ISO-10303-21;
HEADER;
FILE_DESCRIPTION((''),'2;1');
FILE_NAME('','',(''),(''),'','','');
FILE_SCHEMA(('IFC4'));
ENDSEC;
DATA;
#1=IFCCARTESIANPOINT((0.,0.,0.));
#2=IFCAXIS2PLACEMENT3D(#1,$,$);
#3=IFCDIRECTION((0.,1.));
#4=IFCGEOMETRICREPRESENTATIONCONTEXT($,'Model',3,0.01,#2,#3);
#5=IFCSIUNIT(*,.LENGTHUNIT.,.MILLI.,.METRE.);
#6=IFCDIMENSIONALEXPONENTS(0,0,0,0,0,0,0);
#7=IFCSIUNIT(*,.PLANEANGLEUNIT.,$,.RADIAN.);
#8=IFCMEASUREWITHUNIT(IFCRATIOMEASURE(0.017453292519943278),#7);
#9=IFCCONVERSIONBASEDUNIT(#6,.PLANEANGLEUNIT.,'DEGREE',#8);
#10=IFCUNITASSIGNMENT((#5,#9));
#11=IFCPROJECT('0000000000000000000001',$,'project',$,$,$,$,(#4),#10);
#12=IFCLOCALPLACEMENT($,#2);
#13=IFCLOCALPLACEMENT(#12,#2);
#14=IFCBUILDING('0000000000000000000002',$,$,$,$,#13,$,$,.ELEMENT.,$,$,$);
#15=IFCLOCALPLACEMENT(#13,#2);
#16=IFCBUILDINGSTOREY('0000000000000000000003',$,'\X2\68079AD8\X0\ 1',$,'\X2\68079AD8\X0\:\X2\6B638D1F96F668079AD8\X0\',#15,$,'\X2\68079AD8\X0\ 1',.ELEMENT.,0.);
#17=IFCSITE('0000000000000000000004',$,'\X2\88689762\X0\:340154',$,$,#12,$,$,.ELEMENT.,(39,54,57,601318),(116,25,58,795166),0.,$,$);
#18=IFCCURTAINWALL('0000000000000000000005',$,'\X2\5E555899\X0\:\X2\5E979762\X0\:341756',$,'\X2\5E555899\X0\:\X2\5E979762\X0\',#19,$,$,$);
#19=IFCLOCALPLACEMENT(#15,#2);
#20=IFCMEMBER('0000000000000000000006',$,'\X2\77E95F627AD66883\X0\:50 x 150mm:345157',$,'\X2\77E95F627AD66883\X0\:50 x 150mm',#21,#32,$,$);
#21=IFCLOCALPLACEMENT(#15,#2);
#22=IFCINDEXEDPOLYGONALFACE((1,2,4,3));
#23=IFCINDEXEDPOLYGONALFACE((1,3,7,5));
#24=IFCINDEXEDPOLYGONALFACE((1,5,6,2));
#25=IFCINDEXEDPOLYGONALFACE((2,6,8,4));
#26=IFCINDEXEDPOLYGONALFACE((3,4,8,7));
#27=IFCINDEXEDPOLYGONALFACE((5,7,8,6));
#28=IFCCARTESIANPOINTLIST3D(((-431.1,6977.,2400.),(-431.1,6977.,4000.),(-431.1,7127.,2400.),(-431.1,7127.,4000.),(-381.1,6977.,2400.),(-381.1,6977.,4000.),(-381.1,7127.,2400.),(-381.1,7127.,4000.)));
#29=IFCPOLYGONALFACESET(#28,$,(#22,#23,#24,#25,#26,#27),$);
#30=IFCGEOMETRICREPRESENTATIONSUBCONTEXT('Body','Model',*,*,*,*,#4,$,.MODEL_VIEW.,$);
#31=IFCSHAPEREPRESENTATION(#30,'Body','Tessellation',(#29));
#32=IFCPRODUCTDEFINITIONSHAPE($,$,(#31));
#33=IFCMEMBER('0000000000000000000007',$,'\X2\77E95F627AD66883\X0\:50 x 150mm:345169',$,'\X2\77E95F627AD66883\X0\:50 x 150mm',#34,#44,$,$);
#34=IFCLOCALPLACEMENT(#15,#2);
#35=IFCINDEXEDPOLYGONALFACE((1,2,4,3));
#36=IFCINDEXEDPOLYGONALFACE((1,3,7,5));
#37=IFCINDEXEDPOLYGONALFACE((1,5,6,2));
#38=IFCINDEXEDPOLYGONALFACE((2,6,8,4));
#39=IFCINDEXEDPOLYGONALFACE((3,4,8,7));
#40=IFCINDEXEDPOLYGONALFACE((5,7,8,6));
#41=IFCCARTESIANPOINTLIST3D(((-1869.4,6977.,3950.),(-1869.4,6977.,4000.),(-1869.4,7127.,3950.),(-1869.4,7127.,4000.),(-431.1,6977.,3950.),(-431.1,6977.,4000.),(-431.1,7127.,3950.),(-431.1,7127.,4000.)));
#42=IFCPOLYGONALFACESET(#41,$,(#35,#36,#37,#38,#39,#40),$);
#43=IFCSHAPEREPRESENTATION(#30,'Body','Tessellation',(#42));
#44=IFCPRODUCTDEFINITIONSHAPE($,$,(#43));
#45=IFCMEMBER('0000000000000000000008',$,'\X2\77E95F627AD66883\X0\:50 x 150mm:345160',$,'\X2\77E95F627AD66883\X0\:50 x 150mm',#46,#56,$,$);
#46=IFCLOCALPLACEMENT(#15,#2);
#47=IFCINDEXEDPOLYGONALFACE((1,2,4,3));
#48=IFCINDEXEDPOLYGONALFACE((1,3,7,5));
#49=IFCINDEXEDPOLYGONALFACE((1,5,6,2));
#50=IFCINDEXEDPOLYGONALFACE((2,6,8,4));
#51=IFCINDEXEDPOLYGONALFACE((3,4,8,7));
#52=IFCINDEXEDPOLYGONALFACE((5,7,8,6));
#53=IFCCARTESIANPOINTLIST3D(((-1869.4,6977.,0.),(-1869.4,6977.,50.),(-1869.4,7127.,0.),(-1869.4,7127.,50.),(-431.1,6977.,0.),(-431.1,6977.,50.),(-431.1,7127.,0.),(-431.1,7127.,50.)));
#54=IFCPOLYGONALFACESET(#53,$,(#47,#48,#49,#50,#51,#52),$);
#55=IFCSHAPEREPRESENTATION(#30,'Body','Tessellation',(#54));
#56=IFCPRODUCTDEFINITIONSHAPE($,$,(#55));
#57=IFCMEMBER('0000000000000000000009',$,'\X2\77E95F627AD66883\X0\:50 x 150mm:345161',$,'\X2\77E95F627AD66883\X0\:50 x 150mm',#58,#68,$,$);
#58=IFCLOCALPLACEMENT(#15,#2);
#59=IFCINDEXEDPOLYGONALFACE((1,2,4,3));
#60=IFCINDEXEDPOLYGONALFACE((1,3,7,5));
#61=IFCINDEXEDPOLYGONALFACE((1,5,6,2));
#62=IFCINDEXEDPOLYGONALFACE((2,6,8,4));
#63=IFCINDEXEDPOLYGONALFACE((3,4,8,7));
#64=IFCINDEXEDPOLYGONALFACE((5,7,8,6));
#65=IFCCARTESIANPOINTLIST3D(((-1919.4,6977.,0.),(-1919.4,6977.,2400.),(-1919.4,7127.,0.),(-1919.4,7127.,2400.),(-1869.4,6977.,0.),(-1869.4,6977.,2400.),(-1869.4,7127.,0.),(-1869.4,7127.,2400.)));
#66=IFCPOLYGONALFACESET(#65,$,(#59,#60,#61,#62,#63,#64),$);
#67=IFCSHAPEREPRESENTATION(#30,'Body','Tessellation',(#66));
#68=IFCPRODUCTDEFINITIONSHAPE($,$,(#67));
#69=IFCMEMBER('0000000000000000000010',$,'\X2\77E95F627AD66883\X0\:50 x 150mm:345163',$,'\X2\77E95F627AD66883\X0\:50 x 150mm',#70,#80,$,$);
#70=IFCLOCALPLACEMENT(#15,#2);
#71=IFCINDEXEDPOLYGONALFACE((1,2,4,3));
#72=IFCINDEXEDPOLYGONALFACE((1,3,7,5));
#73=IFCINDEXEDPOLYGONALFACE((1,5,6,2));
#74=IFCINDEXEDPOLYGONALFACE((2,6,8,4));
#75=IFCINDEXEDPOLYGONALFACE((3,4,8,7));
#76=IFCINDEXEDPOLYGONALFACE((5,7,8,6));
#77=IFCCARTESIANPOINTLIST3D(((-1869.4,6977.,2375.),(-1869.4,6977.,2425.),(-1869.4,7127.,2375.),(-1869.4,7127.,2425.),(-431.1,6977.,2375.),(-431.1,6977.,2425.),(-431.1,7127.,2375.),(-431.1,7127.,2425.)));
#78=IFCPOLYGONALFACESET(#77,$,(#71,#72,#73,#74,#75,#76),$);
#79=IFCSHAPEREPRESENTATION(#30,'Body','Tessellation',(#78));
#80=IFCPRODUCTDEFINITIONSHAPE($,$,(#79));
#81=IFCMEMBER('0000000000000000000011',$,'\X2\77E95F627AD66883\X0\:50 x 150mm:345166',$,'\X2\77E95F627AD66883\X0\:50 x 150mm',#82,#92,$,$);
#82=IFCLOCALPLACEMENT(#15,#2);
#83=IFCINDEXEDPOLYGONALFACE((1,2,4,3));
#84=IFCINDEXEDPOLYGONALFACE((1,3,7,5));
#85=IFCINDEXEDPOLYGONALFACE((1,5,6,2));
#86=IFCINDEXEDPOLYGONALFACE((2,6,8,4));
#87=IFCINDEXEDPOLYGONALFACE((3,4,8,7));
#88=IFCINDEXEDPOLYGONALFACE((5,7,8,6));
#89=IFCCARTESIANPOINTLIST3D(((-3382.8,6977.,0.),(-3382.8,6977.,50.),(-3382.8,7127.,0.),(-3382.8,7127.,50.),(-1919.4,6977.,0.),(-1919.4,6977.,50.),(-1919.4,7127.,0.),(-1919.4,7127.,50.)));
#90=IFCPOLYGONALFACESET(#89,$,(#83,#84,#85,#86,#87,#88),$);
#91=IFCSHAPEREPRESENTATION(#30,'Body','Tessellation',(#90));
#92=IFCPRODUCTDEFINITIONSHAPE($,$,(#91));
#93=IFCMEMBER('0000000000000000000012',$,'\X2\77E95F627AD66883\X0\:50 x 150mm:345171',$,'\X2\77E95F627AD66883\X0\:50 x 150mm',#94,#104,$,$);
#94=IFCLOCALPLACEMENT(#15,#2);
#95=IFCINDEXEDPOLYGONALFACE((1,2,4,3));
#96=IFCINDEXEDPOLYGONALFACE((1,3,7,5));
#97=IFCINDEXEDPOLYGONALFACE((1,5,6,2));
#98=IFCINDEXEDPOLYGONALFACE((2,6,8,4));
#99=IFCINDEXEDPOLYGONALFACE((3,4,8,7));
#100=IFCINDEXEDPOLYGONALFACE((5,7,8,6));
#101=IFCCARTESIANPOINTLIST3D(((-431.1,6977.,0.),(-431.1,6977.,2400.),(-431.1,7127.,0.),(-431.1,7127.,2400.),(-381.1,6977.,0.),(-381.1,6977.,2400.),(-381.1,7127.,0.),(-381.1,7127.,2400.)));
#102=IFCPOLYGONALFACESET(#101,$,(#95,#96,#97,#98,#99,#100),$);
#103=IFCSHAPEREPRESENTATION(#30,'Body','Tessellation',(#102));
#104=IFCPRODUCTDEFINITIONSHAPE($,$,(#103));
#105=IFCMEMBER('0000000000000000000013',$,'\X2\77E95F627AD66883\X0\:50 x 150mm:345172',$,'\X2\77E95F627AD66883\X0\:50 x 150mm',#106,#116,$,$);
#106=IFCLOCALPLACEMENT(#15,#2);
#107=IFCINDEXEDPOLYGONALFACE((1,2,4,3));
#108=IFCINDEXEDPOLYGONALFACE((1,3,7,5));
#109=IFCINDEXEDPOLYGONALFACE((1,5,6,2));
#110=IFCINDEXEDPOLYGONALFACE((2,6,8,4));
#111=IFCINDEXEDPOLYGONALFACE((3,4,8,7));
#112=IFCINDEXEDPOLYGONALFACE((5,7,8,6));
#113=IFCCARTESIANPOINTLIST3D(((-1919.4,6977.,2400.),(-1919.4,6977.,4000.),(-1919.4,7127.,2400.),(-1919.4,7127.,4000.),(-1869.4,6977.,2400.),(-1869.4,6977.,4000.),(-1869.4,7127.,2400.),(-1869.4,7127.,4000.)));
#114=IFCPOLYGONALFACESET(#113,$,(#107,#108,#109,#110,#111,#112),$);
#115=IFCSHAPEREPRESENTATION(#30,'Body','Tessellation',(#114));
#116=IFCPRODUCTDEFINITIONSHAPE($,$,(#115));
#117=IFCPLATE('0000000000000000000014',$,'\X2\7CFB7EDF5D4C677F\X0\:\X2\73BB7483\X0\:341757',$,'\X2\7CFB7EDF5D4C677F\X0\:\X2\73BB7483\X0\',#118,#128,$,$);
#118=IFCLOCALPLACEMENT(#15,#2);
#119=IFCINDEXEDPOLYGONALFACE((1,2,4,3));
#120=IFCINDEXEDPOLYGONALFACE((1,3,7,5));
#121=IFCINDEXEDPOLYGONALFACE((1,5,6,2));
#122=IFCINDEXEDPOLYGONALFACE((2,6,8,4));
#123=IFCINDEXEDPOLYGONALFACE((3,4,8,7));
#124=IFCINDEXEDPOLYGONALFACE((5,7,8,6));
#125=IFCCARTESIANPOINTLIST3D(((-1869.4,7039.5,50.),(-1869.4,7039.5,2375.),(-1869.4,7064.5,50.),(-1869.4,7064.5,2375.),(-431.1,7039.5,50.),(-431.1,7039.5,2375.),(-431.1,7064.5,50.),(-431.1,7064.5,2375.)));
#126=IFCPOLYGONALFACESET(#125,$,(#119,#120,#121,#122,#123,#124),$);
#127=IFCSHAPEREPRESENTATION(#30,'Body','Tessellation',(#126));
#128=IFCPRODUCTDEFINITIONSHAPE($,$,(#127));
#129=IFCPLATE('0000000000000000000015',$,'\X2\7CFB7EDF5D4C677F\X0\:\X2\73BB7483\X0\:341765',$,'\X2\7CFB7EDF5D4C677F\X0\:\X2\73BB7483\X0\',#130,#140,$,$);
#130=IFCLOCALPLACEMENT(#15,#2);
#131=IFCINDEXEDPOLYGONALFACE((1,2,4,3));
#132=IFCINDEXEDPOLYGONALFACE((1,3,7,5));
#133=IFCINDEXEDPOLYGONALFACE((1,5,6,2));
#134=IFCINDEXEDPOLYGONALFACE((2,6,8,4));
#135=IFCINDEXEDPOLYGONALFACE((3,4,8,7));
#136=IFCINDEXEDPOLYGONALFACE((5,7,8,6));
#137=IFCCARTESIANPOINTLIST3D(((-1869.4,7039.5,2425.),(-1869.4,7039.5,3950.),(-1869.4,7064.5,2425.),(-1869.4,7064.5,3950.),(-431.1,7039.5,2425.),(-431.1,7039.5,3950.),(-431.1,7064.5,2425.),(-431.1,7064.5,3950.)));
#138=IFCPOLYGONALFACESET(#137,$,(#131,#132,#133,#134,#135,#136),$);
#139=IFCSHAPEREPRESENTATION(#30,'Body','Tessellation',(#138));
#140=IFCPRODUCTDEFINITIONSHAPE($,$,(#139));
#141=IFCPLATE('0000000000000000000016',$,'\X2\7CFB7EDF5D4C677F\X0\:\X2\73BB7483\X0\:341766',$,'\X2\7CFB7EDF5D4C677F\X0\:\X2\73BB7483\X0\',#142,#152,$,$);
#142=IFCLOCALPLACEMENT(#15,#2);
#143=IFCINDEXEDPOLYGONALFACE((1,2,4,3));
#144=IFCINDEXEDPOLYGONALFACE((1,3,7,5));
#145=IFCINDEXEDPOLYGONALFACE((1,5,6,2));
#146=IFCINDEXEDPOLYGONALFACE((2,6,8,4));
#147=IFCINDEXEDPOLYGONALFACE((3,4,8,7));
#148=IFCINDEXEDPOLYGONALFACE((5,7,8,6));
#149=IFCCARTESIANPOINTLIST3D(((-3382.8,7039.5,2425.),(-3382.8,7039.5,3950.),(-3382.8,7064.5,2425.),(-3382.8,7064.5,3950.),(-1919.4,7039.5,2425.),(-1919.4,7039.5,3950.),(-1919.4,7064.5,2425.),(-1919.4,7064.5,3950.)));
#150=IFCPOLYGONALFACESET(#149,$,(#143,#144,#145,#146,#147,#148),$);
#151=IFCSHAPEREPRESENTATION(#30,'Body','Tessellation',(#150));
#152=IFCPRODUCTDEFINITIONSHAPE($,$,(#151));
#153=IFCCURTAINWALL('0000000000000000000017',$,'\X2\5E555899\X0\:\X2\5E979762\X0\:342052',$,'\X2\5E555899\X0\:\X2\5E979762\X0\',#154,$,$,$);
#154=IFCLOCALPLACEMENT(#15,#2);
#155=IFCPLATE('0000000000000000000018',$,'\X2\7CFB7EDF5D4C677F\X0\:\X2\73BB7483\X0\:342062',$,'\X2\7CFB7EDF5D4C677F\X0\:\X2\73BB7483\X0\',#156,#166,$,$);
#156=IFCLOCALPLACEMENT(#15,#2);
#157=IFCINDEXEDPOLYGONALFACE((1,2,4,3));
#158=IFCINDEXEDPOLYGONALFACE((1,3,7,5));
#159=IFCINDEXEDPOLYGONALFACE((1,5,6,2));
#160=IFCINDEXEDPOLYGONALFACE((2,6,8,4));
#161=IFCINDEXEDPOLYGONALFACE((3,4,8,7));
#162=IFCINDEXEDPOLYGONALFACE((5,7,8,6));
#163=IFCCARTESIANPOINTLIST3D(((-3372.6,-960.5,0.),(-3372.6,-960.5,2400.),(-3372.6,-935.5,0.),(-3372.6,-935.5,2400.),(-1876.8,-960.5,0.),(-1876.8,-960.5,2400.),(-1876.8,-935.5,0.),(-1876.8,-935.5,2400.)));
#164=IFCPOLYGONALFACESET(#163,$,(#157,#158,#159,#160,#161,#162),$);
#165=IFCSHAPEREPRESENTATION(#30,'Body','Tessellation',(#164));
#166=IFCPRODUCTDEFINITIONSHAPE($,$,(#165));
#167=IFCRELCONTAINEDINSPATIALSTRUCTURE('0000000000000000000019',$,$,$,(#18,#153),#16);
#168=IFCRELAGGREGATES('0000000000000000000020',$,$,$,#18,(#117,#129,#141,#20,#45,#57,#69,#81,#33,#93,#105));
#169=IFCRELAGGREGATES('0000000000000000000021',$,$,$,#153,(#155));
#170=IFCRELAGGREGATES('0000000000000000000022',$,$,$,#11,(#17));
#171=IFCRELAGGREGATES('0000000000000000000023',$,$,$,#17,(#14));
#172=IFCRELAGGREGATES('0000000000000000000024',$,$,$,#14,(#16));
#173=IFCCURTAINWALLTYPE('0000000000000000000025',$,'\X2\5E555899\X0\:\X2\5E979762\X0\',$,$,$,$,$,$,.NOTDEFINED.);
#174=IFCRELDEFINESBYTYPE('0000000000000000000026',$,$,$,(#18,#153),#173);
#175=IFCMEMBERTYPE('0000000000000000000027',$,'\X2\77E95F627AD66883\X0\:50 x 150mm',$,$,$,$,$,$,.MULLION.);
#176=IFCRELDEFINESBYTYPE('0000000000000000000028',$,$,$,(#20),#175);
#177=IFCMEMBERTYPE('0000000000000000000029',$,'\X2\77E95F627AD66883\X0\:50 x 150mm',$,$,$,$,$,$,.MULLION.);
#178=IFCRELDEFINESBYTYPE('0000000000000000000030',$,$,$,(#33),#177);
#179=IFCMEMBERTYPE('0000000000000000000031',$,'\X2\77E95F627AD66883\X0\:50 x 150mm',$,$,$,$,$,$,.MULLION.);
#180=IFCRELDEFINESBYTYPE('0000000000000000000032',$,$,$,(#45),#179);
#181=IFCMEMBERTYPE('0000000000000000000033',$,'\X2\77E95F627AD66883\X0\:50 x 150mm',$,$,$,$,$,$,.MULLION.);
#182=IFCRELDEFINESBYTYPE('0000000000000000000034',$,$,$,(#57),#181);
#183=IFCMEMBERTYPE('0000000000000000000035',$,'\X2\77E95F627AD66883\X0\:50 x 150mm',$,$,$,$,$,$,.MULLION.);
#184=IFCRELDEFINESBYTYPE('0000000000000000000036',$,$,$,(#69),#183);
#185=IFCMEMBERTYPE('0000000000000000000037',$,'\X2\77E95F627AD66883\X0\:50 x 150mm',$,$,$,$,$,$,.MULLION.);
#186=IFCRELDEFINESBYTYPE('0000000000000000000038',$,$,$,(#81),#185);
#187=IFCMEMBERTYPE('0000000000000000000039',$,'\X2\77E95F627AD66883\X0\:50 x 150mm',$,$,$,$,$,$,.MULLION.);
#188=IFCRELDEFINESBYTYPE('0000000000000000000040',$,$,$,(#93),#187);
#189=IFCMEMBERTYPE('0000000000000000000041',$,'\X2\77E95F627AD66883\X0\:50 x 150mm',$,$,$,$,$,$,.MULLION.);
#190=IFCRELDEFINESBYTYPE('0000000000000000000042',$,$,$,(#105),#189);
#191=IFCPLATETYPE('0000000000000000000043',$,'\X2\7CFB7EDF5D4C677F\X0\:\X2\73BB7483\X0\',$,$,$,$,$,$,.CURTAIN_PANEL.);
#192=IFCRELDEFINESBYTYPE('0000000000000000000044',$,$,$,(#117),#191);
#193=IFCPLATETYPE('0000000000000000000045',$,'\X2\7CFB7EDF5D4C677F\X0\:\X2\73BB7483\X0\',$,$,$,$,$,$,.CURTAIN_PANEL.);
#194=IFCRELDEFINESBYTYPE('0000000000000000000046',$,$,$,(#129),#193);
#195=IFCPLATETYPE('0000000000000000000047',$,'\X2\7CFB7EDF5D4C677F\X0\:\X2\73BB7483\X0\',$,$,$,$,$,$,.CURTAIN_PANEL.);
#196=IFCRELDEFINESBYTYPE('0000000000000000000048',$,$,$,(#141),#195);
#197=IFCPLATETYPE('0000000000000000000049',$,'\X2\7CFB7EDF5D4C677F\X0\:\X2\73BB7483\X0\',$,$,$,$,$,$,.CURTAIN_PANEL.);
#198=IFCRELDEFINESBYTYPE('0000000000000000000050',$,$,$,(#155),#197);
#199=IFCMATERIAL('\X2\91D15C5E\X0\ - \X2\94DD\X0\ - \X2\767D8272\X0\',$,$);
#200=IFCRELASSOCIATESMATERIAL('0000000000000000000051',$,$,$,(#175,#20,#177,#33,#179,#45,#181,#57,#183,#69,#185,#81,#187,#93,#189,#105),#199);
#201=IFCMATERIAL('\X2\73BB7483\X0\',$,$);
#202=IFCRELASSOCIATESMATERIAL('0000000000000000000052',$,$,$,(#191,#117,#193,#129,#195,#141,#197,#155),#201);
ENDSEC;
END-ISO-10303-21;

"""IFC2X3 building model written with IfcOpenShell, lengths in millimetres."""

from ifc_helpers import new_model, entity, si_unit, converted_unit, direction, frame, origin, origin_2d_with_axis, place, context, subcontext, project, spatial, rectangle, extrude, source, transform, mapped, material, type_object, type_shapes, element, aggregate, save


model = new_model("IFC2X3")

# Units and contexts
model_context = context("Model", 3, precision=0.01, world=origin(), true_north=direction((0.0, 1.0)))
body_context = subcontext(model_context, "Body", "Model", "MODEL_VIEW")
ifc_project = project(units=[si_unit("LENGTHUNIT", "METRE", prefix="MILLI"), converted_unit("PLANEANGLEUNIT", "DEGREE", entity("IfcRatioMeasure", 0.017453292519943278), si_unit("PLANEANGLEUNIT", "RADIAN"), dimensions=[0, 0, 0, 0, 0, 0, 0])], contexts=[model_context])

# Site, building, storey
site_placement = place(None, origin())
site = spatial("IfcSite", under=ifc_project, at=site_placement, Name="表面:340154", CompositionType="ELEMENT", RefLatitude=(39, 54, 57, 601318), RefLongitude=(116, 25, 58, 795166), RefElevation=0.0)
building_placement = place(site_placement, origin())
building = spatial("IfcBuilding", under=site, at=building_placement, CompositionType="ELEMENT")
storey_placement = place(building_placement, origin())
storey = spatial("IfcBuildingStorey", under=building, at=storey_placement, Name="标高 1", ObjectType="标高:正负零标高", LongName="标高 1", CompositionType="ELEMENT", Elevation=0.0)

# Curtain wall, members, plates
curtain_wall_type = type_object("IfcCurtainWallType", Name="幕墙:店面", PredefinedType="NOTDEFINED")
curtain_wall_1_placement = place(storey_placement, origin())
curtain_wall_1 = element("IfcCurtainWall", 1, at=curtain_wall_1_placement, inside=storey, type_object=curtain_wall_type, Name="幕墙:店面:341756", ObjectType="幕墙:店面")
ifc_material_1 = material(Name="金属 - 铝 - 白色")
member_type_1 = type_object("IfcMemberType", Name="矩形竖梃:50 x 150mm", PredefinedType="MULLION", material=ifc_material_1)
shared_shape_1 = source(origin(), body_context, "Body", "SweptSolid", [
    extrude(rectangle(XDim=150.0, YDim=50.0, at=origin_2d_with_axis()), frame((-25.0, 0.0, -1600.0), z_axis=(0.0, 0.0, 1.0), x_axis=(0.0, -1.0, 0.0)), (0.0, 0.0, 1.0), 1600.0),
])
type_shapes(member_type_1, [shared_shape_1])
member_1_placement = place(curtain_wall_1_placement, frame((-381.1, 7052.0, 4000.0)))
member_1 = element("IfcMember", 2, at=member_1_placement, type_object=member_type_1, material=ifc_material_1, Name="矩形竖梃:50 x 150mm:345157", ObjectType="矩形竖梃:50 x 150mm", context=body_context, shape_type="MappedRepresentation", body=[
    mapped(shared_shape_1, transform((0.0, 0.0, 0.0), scale=1.0)),
])
member_type_2 = type_object("IfcMemberType", Name="矩形竖梃:50 x 150mm", PredefinedType="MULLION", material=ifc_material_1)
shared_shape_2 = source(origin(), body_context, "Body", "SweptSolid", [
    extrude(rectangle(XDim=150.0, YDim=50.0, at=origin_2d_with_axis()), frame((-25.0, 0.0, -1438.3), z_axis=(0.0, 0.0, 1.0), x_axis=(0.0, -1.0, 0.0)), (0.0, 0.0, 1.0), 1438.3),
])
type_shapes(member_type_2, [shared_shape_2])
member_2_placement = place(curtain_wall_1_placement, frame((-1869.4, 7052.0, 4000.0), z_axis=(-1.0, 0.0, 0.0), x_axis=(0.0, 0.0, 1.0)))
member_2 = element("IfcMember", 3, at=member_2_placement, type_object=member_type_2, material=ifc_material_1, Name="矩形竖梃:50 x 150mm:345169", ObjectType="矩形竖梃:50 x 150mm", context=body_context, shape_type="MappedRepresentation", body=[
    mapped(shared_shape_2, transform((0.0, 0.0, 0.0), scale=1.0)),
])
member_type_3 = type_object("IfcMemberType", Name="矩形竖梃:50 x 150mm", PredefinedType="MULLION", material=ifc_material_1)
shared_shape_3 = source(origin(), body_context, "Body", "SweptSolid", [
    extrude(rectangle(XDim=150.0, YDim=50.0, at=origin_2d_with_axis()), frame((-25.0, 0.0, -1438.3), z_axis=(0.0, 0.0, 1.0), x_axis=(0.0, -1.0, 0.0)), (0.0, 0.0, 1.0), 1438.3),
])
type_shapes(member_type_3, [shared_shape_3])
member_3_placement = place(curtain_wall_1_placement, frame((-431.1, 7052.0, 0.0), z_axis=(1.0, 0.0, 0.0), x_axis=(0.0, 0.0, -1.0)))
member_3 = element("IfcMember", 4, at=member_3_placement, type_object=member_type_3, material=ifc_material_1, Name="矩形竖梃:50 x 150mm:345160", ObjectType="矩形竖梃:50 x 150mm", context=body_context, shape_type="MappedRepresentation", body=[
    mapped(shared_shape_3, transform((0.0, 0.0, 0.0), scale=1.0)),
])
member_type_4 = type_object("IfcMemberType", Name="矩形竖梃:50 x 150mm", PredefinedType="MULLION", material=ifc_material_1)
shared_shape_4 = source(origin(), body_context, "Body", "SweptSolid", [
    extrude(rectangle(XDim=150.0, YDim=50.0, at=origin_2d_with_axis()), frame((0.0, 0.0, -2400.0), z_axis=(0.0, 0.0, 1.0), x_axis=(0.0, -1.0, 0.0)), (0.0, 0.0, 1.0), 2400.0),
])
type_shapes(member_type_4, [shared_shape_4])
member_4_placement = place(curtain_wall_1_placement, frame((-1894.4, 7052.0, 0.0), z_axis=(0.0, 0.0, -1.0), x_axis=(-1.0, 0.0, 0.0)))
member_4 = element("IfcMember", 5, at=member_4_placement, type_object=member_type_4, material=ifc_material_1, Name="矩形竖梃:50 x 150mm:345161", ObjectType="矩形竖梃:50 x 150mm", context=body_context, shape_type="MappedRepresentation", body=[
    mapped(shared_shape_4, transform((0.0, 0.0, 0.0), scale=1.0)),
])
member_type_5 = type_object("IfcMemberType", Name="矩形竖梃:50 x 150mm", PredefinedType="MULLION", material=ifc_material_1)
shared_shape_5 = source(origin(), body_context, "Body", "SweptSolid", [
    extrude(rectangle(XDim=150.0, YDim=50.0, at=origin_2d_with_axis()), frame((0.0, 0.0, -1438.3), z_axis=(0.0, 0.0, 1.0), x_axis=(0.0, -1.0, 0.0)), (0.0, 0.0, 1.0), 1438.3),
])
type_shapes(member_type_5, [shared_shape_5])
member_5_placement = place(curtain_wall_1_placement, frame((-1869.4, 7052.0, 2400.0), z_axis=(-1.0, 0.0, 0.0), x_axis=(0.0, 0.0, 1.0)))
member_5 = element("IfcMember", 6, at=member_5_placement, type_object=member_type_5, material=ifc_material_1, Name="矩形竖梃:50 x 150mm:345163", ObjectType="矩形竖梃:50 x 150mm", context=body_context, shape_type="MappedRepresentation", body=[
    mapped(shared_shape_5, transform((0.0, 0.0, 0.0), scale=1.0)),
])
member_type_6 = type_object("IfcMemberType", Name="矩形竖梃:50 x 150mm", PredefinedType="MULLION", material=ifc_material_1)
shared_shape_6 = source(origin(), body_context, "Body", "SweptSolid", [
    extrude(rectangle(XDim=150.0, YDim=50.0, at=origin_2d_with_axis()), frame((-25.0, 0.0, -1463.3), z_axis=(0.0, 0.0, 1.0), x_axis=(0.0, -1.0, 0.0)), (0.0, 0.0, 1.0), 1463.3),
])
type_shapes(member_type_6, [shared_shape_6])
member_6_placement = place(curtain_wall_1_placement, frame((-1919.4, 7052.0, 0.0), z_axis=(1.0, 0.0, 0.0), x_axis=(0.0, 0.0, -1.0)))
member_6 = element("IfcMember", 7, at=member_6_placement, type_object=member_type_6, material=ifc_material_1, Name="矩形竖梃:50 x 150mm:345166", ObjectType="矩形竖梃:50 x 150mm", context=body_context, shape_type="MappedRepresentation", body=[
    mapped(shared_shape_6, transform((0.0, 0.0, 0.0), scale=1.0)),
])
member_type_7 = type_object("IfcMemberType", Name="矩形竖梃:50 x 150mm", PredefinedType="MULLION", material=ifc_material_1)
shared_shape_7 = source(origin(), body_context, "Body", "SweptSolid", [
    extrude(rectangle(XDim=150.0, YDim=50.0, at=origin_2d_with_axis()), frame((-25.0, 0.0, -2400.0), z_axis=(0.0, 0.0, 1.0), x_axis=(0.0, -1.0, 0.0)), (0.0, 0.0, 1.0), 2400.0),
])
type_shapes(member_type_7, [shared_shape_7])
member_7_placement = place(curtain_wall_1_placement, frame((-381.1, 7052.0, 2400.0)))
member_7 = element("IfcMember", 8, at=member_7_placement, type_object=member_type_7, material=ifc_material_1, Name="矩形竖梃:50 x 150mm:345171", ObjectType="矩形竖梃:50 x 150mm", context=body_context, shape_type="MappedRepresentation", body=[
    mapped(shared_shape_7, transform((0.0, 0.0, 0.0), scale=1.0)),
])
member_type_8 = type_object("IfcMemberType", Name="矩形竖梃:50 x 150mm", PredefinedType="MULLION", material=ifc_material_1)
shared_shape_8 = source(origin(), body_context, "Body", "SweptSolid", [
    extrude(rectangle(XDim=150.0, YDim=50.0, at=origin_2d_with_axis()), frame((0.0, 0.0, -1600.0), z_axis=(0.0, 0.0, 1.0), x_axis=(0.0, -1.0, 0.0)), (0.0, 0.0, 1.0), 1600.0),
])
type_shapes(member_type_8, [shared_shape_8])
member_8_placement = place(curtain_wall_1_placement, frame((-1894.4, 7052.0, 2400.0), z_axis=(0.0, 0.0, -1.0), x_axis=(-1.0, 0.0, 0.0)))
member_8 = element("IfcMember", 9, at=member_8_placement, type_object=member_type_8, material=ifc_material_1, Name="矩形竖梃:50 x 150mm:345172", ObjectType="矩形竖梃:50 x 150mm", context=body_context, shape_type="MappedRepresentation", body=[
    mapped(shared_shape_8, transform((0.0, 0.0, 0.0), scale=1.0)),
])
ifc_material_2 = material(Name="玻璃")
plate_type_1 = type_object("IfcPlateType", Name="系统嵌板:玻璃", PredefinedType="CURTAIN_PANEL", material=ifc_material_2)
shared_shape_9 = source(origin(), body_context, "Body", "SweptSolid", [
    extrude(rectangle(XDim=25.0, YDim=1438.3, at=origin_2d_with_axis()), frame((0.0, 0.0, 0.0), z_axis=(0.0, 0.0, 1.0), x_axis=(0.0, 1.0, 0.0)), (0.0, 0.0, 1.0), 2325.0),
])
type_shapes(plate_type_1, [shared_shape_9])
plate_1_placement = place(curtain_wall_1_placement, frame((-1150.3, 7052.0, 50.0), z_axis=(0.0, 0.0, 1.0), x_axis=(-1.0, 0.0, 0.0)))
plate_1 = element("IfcPlate", 10, at=plate_1_placement, type_object=plate_type_1, material=ifc_material_2, Name="系统嵌板:玻璃:341757", ObjectType="系统嵌板:玻璃", context=body_context, shape_type="MappedRepresentation", body=[
    mapped(shared_shape_9, transform((0.0, 0.0, 0.0), scale=1.0)),
])
plate_type_2 = type_object("IfcPlateType", Name="系统嵌板:玻璃", PredefinedType="CURTAIN_PANEL", material=ifc_material_2)
shared_shape_10 = source(origin(), body_context, "Body", "SweptSolid", [
    extrude(rectangle(XDim=25.0, YDim=1438.3, at=origin_2d_with_axis()), frame((0.0, 0.0, 0.0), z_axis=(0.0, 0.0, 1.0), x_axis=(0.0, 1.0, 0.0)), (0.0, 0.0, 1.0), 1525.0),
])
type_shapes(plate_type_2, [shared_shape_10])
plate_2_placement = place(curtain_wall_1_placement, frame((-1150.3, 7052.0, 2425.0), z_axis=(0.0, 0.0, 1.0), x_axis=(-1.0, 0.0, 0.0)))
plate_2 = element("IfcPlate", 11, at=plate_2_placement, type_object=plate_type_2, material=ifc_material_2, Name="系统嵌板:玻璃:341765", ObjectType="系统嵌板:玻璃", context=body_context, shape_type="MappedRepresentation", body=[
    mapped(shared_shape_10, transform((0.0, 0.0, 0.0), scale=1.0)),
])
plate_type_3 = type_object("IfcPlateType", Name="系统嵌板:玻璃", PredefinedType="CURTAIN_PANEL", material=ifc_material_2)
shared_shape_11 = source(origin(), body_context, "Body", "SweptSolid", [
    extrude(rectangle(XDim=25.0, YDim=1463.3, at=origin_2d_with_axis()), frame((0.0, 0.0, 0.0), z_axis=(0.0, 0.0, 1.0), x_axis=(0.0, 1.0, 0.0)), (0.0, 0.0, 1.0), 1525.0),
])
type_shapes(plate_type_3, [shared_shape_11])
plate_3_placement = place(curtain_wall_1_placement, frame((-2651.1, 7052.0, 2425.0), z_axis=(0.0, 0.0, 1.0), x_axis=(-1.0, 0.0, 0.0)))
plate_3 = element("IfcPlate", 12, at=plate_3_placement, type_object=plate_type_3, material=ifc_material_2, Name="系统嵌板:玻璃:341766", ObjectType="系统嵌板:玻璃", context=body_context, shape_type="MappedRepresentation", body=[
    mapped(shared_shape_11, transform((0.0, 0.0, 0.0), scale=1.0)),
])
aggregate(curtain_wall_1, [plate_1, plate_2, plate_3, member_1, member_3, member_4, member_5, member_6, member_2, member_7, member_8])

# Curtain wall, plate
curtain_wall_2_placement = place(storey_placement, origin())
curtain_wall_2 = element("IfcCurtainWall", 13, at=curtain_wall_2_placement, inside=storey, type_object=curtain_wall_type, Name="幕墙:店面:342052", ObjectType="幕墙:店面")
plate_type_4 = type_object("IfcPlateType", Name="系统嵌板:玻璃", PredefinedType="CURTAIN_PANEL", material=ifc_material_2)
shared_shape_12 = source(origin(), body_context, "Body", "SweptSolid", [
    extrude(rectangle(XDim=25.0, YDim=1495.8, at=origin_2d_with_axis()), frame((0.0, 0.0, 0.0), z_axis=(0.0, 0.0, 1.0), x_axis=(0.0, 1.0, 0.0)), (0.0, 0.0, 1.0), 2400.0),
])
type_shapes(plate_type_4, [shared_shape_12])
plate_4_placement = place(curtain_wall_2_placement, frame((-2624.7, -948.0, 0.0)))
plate_4 = element("IfcPlate", 14, at=plate_4_placement, type_object=plate_type_4, material=ifc_material_2, Name="系统嵌板:玻璃:342062", ObjectType="系统嵌板:玻璃", context=body_context, shape_type="MappedRepresentation", body=[
    mapped(shared_shape_12, transform((0.0, 0.0, 0.0), scale=1.0)),
])
aggregate(curtain_wall_2, [plate_4])

save(model, "model.ifc")
